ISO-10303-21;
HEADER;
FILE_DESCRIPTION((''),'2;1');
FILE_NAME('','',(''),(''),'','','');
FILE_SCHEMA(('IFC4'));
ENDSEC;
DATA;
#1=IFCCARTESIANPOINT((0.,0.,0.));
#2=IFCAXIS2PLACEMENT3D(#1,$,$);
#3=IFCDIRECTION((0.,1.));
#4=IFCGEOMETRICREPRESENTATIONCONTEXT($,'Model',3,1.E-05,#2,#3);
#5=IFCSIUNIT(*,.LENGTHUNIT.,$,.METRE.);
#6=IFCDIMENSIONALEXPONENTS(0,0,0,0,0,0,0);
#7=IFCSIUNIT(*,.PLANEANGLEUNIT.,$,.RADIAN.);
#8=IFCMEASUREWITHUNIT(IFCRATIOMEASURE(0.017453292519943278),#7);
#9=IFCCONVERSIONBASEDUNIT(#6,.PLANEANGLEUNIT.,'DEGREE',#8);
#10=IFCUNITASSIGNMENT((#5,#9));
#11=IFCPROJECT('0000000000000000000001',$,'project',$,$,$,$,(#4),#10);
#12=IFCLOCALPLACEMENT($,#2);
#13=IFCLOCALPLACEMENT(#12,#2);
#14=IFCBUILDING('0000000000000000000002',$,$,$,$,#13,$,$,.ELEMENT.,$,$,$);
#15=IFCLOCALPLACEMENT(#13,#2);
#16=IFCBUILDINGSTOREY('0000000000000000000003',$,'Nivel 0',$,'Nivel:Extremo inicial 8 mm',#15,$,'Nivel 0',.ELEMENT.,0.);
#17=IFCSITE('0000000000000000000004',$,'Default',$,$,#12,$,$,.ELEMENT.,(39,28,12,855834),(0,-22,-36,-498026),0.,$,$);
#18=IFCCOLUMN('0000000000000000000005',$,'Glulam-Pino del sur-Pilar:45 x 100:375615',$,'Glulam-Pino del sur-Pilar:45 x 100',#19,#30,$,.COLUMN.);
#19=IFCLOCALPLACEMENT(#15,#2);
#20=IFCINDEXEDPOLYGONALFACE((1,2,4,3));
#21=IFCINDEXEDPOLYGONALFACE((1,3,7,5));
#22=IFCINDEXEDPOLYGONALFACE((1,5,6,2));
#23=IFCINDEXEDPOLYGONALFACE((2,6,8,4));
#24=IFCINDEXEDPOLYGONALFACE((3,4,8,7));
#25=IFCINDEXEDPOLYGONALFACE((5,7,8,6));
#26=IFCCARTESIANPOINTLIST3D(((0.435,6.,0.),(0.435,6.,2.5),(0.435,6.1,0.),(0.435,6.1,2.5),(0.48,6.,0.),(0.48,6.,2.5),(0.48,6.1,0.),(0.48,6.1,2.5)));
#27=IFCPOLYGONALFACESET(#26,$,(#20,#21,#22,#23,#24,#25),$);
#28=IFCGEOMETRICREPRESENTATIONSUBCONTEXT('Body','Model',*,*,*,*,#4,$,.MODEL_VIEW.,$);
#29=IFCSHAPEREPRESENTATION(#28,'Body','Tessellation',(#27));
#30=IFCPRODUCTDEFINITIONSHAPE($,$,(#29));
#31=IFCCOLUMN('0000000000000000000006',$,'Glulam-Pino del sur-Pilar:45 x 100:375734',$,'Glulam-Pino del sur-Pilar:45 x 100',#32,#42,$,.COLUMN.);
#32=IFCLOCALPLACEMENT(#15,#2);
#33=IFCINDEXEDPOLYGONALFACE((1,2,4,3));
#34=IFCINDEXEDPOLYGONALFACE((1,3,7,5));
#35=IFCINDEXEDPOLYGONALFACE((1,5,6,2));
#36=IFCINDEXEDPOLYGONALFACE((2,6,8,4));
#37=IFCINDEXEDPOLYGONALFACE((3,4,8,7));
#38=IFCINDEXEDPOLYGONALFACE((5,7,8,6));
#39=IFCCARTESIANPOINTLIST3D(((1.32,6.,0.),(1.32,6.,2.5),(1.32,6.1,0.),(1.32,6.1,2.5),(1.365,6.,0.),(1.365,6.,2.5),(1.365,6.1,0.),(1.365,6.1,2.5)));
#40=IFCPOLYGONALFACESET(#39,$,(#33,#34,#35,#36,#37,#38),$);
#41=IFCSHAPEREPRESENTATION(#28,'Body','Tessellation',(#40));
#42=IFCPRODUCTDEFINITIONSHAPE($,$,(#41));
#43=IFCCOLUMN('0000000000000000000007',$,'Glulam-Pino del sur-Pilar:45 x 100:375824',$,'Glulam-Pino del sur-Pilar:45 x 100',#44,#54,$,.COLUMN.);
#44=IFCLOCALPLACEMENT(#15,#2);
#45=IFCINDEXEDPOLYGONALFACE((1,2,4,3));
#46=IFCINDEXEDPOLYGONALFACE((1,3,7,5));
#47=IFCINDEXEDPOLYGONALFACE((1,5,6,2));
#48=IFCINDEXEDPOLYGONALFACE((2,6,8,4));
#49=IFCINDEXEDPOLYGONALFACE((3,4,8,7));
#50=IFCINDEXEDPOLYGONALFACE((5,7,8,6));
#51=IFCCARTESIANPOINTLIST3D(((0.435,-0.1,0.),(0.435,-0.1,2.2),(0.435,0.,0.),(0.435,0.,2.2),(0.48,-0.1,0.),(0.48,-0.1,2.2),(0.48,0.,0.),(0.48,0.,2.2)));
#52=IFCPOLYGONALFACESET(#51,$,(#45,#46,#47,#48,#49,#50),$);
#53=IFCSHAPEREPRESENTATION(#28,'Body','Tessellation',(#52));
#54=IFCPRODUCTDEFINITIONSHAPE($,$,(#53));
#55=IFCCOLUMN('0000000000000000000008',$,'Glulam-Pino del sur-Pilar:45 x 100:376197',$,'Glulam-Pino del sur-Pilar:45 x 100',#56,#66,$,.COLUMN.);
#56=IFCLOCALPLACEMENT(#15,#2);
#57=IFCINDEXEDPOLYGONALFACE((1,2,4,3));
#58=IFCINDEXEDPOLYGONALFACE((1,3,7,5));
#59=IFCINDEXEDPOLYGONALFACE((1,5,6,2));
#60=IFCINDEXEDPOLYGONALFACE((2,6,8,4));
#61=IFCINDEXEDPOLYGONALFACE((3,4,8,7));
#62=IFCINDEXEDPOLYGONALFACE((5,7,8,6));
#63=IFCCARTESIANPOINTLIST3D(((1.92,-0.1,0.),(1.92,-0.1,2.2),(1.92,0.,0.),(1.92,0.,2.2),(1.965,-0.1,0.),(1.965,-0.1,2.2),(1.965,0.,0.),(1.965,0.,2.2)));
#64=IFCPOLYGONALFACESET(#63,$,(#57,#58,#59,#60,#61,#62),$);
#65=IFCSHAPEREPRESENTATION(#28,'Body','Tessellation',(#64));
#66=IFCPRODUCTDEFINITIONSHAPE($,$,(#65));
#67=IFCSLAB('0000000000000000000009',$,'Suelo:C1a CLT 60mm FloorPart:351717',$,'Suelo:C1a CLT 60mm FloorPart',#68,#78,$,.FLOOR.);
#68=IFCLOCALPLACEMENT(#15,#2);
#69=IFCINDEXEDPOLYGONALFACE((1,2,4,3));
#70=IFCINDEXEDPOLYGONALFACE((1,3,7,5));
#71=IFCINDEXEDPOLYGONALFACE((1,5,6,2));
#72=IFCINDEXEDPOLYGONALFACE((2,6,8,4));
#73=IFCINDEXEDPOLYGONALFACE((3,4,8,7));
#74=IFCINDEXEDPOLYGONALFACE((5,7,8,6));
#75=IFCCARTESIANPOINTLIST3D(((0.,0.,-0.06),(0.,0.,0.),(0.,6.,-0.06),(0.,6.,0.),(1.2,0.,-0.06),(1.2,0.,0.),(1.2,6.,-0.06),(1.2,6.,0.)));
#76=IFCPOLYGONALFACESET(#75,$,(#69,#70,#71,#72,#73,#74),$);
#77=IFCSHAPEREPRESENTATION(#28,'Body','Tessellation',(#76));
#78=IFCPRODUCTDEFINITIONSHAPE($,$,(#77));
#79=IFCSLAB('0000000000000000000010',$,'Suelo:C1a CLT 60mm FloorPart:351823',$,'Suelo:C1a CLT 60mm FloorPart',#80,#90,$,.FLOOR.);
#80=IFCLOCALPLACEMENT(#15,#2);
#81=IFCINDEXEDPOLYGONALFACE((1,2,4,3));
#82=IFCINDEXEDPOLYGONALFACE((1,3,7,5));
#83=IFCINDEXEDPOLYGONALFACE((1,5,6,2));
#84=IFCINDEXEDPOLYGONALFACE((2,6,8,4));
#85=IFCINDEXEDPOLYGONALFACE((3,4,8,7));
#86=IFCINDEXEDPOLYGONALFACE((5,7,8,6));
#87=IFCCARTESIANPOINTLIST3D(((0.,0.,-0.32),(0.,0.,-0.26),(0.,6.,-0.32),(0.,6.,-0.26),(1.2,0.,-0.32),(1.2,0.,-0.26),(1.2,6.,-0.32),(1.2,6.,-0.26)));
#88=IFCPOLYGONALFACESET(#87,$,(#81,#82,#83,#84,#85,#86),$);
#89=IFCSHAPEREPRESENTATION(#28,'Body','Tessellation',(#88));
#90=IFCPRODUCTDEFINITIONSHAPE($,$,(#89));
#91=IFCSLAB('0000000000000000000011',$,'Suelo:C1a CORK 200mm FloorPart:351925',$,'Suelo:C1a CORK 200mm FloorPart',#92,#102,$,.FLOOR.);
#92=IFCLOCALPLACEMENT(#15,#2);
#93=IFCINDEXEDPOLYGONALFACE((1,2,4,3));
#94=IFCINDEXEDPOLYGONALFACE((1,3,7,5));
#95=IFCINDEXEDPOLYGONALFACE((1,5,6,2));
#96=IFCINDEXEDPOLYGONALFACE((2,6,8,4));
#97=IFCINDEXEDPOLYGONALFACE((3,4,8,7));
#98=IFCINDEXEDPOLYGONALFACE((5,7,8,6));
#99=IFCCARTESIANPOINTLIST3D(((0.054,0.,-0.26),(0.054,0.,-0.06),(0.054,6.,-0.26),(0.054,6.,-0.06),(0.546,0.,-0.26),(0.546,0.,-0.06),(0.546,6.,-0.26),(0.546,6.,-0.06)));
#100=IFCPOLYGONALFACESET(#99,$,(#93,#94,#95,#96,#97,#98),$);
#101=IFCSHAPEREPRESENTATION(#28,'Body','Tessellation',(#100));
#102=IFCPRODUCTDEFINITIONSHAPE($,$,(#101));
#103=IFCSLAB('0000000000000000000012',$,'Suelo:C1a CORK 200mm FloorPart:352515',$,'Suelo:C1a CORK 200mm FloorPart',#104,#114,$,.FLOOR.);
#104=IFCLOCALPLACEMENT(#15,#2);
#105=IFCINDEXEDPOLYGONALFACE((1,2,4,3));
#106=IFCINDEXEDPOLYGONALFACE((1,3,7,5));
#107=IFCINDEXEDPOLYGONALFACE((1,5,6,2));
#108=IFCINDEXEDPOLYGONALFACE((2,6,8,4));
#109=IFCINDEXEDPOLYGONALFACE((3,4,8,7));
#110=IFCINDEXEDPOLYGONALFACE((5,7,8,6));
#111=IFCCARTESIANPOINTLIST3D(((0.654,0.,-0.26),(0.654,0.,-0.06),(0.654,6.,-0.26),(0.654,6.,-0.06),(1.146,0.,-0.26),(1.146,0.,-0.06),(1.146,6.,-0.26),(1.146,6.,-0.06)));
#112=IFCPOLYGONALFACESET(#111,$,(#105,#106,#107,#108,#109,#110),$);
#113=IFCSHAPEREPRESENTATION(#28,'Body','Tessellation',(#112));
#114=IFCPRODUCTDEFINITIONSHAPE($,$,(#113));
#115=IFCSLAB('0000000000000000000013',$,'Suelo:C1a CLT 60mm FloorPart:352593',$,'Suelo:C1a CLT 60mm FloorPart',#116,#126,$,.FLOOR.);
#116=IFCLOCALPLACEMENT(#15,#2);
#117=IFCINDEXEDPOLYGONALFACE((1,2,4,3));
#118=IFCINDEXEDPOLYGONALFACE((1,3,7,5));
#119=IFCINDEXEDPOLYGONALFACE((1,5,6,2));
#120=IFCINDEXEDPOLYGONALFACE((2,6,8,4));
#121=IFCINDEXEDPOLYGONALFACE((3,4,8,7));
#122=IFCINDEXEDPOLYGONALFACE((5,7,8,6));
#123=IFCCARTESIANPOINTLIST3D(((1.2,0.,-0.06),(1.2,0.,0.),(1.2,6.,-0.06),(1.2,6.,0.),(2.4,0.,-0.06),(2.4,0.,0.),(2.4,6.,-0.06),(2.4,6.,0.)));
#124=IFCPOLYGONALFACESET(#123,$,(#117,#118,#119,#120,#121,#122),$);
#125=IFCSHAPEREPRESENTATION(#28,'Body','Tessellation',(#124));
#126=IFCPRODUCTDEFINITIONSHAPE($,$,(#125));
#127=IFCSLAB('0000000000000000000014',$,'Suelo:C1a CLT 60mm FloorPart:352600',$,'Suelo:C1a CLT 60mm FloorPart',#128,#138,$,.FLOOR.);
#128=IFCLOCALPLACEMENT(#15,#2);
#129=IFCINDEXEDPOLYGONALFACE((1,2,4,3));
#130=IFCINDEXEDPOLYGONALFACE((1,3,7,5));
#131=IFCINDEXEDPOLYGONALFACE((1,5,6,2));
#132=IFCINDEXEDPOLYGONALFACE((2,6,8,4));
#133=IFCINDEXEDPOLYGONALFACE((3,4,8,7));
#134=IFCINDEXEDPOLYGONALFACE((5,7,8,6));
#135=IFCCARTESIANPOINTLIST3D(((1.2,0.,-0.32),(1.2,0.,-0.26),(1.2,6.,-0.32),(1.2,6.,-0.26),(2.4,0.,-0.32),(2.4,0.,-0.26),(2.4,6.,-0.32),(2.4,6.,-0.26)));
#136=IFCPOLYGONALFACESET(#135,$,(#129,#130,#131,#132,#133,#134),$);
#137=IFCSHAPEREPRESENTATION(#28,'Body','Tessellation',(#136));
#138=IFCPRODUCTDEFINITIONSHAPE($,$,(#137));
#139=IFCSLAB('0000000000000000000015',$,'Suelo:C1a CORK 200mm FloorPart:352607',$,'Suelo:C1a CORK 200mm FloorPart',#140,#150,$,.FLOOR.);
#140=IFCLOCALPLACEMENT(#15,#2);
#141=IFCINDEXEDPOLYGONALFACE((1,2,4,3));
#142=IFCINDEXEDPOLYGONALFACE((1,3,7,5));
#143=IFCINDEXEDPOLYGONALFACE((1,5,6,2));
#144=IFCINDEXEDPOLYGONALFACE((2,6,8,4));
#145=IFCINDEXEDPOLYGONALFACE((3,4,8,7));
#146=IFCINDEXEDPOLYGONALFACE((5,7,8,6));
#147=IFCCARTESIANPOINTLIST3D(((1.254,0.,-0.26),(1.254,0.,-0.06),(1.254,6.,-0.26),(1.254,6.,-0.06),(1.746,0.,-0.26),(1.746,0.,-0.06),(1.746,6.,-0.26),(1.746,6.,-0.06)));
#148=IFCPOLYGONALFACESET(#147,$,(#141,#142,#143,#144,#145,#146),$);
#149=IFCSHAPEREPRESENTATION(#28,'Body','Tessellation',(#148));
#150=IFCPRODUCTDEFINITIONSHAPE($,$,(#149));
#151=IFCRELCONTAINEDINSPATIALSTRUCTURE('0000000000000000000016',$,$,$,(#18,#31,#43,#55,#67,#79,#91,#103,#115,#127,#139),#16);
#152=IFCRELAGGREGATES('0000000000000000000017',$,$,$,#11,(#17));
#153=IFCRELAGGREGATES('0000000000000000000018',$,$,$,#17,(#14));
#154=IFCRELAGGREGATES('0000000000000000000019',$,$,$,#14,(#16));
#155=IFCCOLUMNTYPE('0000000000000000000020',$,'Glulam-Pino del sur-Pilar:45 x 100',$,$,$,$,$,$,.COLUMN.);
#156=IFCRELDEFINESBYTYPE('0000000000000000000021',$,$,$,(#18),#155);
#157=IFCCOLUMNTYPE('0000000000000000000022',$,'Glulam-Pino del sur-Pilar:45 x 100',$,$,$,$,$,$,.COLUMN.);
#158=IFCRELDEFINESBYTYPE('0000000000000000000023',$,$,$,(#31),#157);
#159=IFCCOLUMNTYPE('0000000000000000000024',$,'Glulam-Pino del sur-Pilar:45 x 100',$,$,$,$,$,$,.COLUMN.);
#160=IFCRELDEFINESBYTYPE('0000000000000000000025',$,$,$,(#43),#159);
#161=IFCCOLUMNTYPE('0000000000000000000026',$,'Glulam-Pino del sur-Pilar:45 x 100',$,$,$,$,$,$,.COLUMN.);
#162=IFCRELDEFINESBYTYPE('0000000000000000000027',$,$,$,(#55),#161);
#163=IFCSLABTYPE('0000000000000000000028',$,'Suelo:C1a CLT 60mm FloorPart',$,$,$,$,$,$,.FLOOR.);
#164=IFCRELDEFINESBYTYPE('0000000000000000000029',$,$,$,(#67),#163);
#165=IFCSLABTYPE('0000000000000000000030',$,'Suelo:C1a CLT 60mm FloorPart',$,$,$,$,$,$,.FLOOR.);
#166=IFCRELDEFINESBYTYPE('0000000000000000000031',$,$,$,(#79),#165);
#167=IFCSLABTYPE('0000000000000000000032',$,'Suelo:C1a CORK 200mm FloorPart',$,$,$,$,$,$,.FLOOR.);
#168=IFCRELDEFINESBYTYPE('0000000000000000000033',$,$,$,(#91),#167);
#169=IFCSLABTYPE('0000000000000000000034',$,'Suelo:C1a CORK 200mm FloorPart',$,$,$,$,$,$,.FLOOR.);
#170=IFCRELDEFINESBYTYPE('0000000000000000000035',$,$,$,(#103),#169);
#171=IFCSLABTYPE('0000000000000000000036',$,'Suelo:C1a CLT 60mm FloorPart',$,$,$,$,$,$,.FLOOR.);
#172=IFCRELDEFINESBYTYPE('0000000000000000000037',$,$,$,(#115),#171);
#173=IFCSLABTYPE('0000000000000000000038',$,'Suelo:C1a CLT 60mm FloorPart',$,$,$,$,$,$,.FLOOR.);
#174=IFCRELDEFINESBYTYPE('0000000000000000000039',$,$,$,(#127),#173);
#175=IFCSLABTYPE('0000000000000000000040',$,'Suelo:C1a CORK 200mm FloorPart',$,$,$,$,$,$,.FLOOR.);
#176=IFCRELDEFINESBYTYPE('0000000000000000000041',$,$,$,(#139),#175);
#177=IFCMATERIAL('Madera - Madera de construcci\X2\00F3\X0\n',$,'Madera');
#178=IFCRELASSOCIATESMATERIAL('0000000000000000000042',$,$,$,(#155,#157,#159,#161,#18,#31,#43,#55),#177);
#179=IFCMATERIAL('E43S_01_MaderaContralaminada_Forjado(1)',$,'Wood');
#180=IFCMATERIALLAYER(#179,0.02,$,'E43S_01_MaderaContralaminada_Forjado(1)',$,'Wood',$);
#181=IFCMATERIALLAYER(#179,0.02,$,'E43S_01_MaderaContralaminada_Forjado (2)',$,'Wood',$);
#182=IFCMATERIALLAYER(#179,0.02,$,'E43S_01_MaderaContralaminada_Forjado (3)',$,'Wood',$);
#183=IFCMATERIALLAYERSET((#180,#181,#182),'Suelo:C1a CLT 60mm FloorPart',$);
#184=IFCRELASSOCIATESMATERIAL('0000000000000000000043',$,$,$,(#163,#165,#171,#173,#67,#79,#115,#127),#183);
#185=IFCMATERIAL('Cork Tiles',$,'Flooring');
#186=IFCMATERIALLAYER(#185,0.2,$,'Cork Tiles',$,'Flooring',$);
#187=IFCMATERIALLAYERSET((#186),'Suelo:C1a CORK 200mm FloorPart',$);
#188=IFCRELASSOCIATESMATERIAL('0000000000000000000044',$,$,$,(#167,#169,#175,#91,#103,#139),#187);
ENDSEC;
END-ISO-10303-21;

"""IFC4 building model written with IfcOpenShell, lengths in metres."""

from ifc_helpers import new_model, entity, si_unit, converted_unit, direction, frame, frame_2d, origin, origin_2d_with_axis, place, context, subcontext, project, spatial, polyline, segment, composite_curve, rectangle, outline, extrude, source, transform, mapped, material, layer, layer_set, layer_usage, material_profile, profile_set, profile_usage, type_object, type_shapes, element, save


model = new_model("IFC4")

# Units and contexts
model_context = context("Model", 3, precision=1e-05, world=origin(), true_north=direction((0.0, 1.0)))
body_context = subcontext(model_context, "Body", "Model", "MODEL_VIEW")
ifc_project = project(units=[si_unit("LENGTHUNIT", "METRE"), converted_unit("PLANEANGLEUNIT", "DEGREE", entity("IfcRatioMeasure", 0.017453292519943278), si_unit("PLANEANGLEUNIT", "RADIAN"), dimensions=[0, 0, 0, 0, 0, 0, 0])], contexts=[model_context])

# Site, building, storey
site_placement = place(None, origin())
site = spatial("IfcSite", under=ifc_project, at=site_placement, Name="Default", CompositionType="ELEMENT", RefLatitude=(39, 28, 12, 855834), RefLongitude=(0, -22, -36, -498026), RefElevation=0.0)
building_placement = place(site_placement, origin())
building = spatial("IfcBuilding", under=site, at=building_placement, CompositionType="ELEMENT")
storey_placement = place(building_placement, origin())
storey = spatial("IfcBuildingStorey", under=building, at=storey_placement, Name="Nivel 0", ObjectType="Nivel:Extremo inicial 8 mm", LongName="Nivel 0", CompositionType="ELEMENT", Elevation=0.0)

# Columns
ifc_material_1 = material(Name="Madera - Madera de construcción", Category="Madera")
ifc_material_profile_1 = material_profile(ifc_material_1, outline(composite_curve([segment(polyline([(0.0225, 0.05, 0.0), (0.0225, -0.05, 0.0)]), True, "CONTINUOUS"), segment(polyline([(0.0225, -0.05, 0.0), (-0.0225, -0.05, 0.0)]), True, "CONTINUOUS"), segment(polyline([(-0.0225, -0.05, 0.0), (-0.0225, 0.05, 0.0)]), True, "CONTINUOUS"), segment(polyline([(-0.0225, 0.05, 0.0), (0.0225, 0.05, 0.0)]), True, "CONTINUOUS")], self_intersect=False), kind="CURVE"), Name="45 x 100")
ifc_material_profile_2 = material_profile(ifc_material_1, outline(composite_curve([segment(polyline([(0.0225, 0.05, 2.5), (-0.0225, 0.05, 2.5)]), True, "CONTINUOUS"), segment(polyline([(-0.0225, 0.05, 2.5), (-0.0225, -0.05, 2.5)]), True, "CONTINUOUS"), segment(polyline([(-0.0225, -0.05, 2.5), (0.0225, -0.05, 2.5)]), True, "CONTINUOUS"), segment(polyline([(0.0225, -0.05, 2.5), (0.0225, 0.05, 2.5)]), True, "CONTINUOUS")], self_intersect=False), kind="CURVE"), Name="45 x 100")
ifc_profile_set = profile_set([ifc_material_profile_1, ifc_material_profile_2], Name="45 x 100")
ifc_profile_usage_1 = profile_usage(ifc_profile_set)
column_type_1 = type_object("IfcColumnType", Name="Glulam-Pino del sur-Pilar:45 x 100", PredefinedType="COLUMN", material=ifc_profile_set)
shared_shape_1 = source(origin(), body_context, "Body", "SweptSolid", [
    extrude(rectangle(XDim=0.1, YDim=0.045, at=origin_2d_with_axis()), frame((0.0, 0.0, 0.0), z_axis=(0.0, 0.0, 1.0), x_axis=(0.0, -1.0, 0.0)), (0.0, 0.0, 1.0), 2.5),
])
type_shapes(column_type_1, [shared_shape_1])
column_1_placement = place(storey_placement, frame((0.4575, 6.05, 0.0)))
element("IfcColumn", 1, at=column_1_placement, inside=storey, type_object=column_type_1, material=ifc_profile_usage_1, Name="Glulam-Pino del sur-Pilar:45 x 100:375615", ObjectType="Glulam-Pino del sur-Pilar:45 x 100", PredefinedType="COLUMN", context=body_context, shape_type="MappedRepresentation", body=[
    mapped(shared_shape_1, transform((0.0, 0.0, 0.0), scale=1.0)),
])
ifc_profile_usage_2 = profile_usage(ifc_profile_set)
column_type_2 = type_object("IfcColumnType", Name="Glulam-Pino del sur-Pilar:45 x 100", PredefinedType="COLUMN", material=ifc_profile_set)
shared_shape_2 = source(origin(), body_context, "Body", "SweptSolid", [
    extrude(rectangle(XDim=0.1, YDim=0.045, at=origin_2d_with_axis()), frame((0.0, 0.0, 0.0), z_axis=(0.0, 0.0, 1.0), x_axis=(0.0, -1.0, 0.0)), (0.0, 0.0, 1.0), 2.5),
])
type_shapes(column_type_2, [shared_shape_2])
column_2_placement = place(storey_placement, frame((1.3425, 6.05, 0.0), z_axis=(0.0, 0.0, 1.0), x_axis=(-1.0, 0.0, 0.0)))
element("IfcColumn", 2, at=column_2_placement, inside=storey, type_object=column_type_2, material=ifc_profile_usage_2, Name="Glulam-Pino del sur-Pilar:45 x 100:375734", ObjectType="Glulam-Pino del sur-Pilar:45 x 100", PredefinedType="COLUMN", context=body_context, shape_type="MappedRepresentation", body=[
    mapped(shared_shape_2, transform((0.0, 0.0, 0.0), scale=1.0)),
])
ifc_profile_usage_3 = profile_usage(ifc_profile_set)
column_type_3 = type_object("IfcColumnType", Name="Glulam-Pino del sur-Pilar:45 x 100", PredefinedType="COLUMN", material=ifc_profile_set)
shared_shape_3 = source(origin(), body_context, "Body", "SweptSolid", [
    extrude(rectangle(XDim=0.1, YDim=0.045, at=origin_2d_with_axis()), frame((0.0, 0.0, 0.0), z_axis=(0.0, 0.0, 1.0), x_axis=(0.0, -1.0, 0.0)), (0.0, 0.0, 1.0), 2.2),
])
type_shapes(column_type_3, [shared_shape_3])
column_3_placement = place(storey_placement, frame((0.4575, -0.05, 0.0), z_axis=(0.0, 0.0, 1.0), x_axis=(-1.0, 0.0, 0.0)))
element("IfcColumn", 3, at=column_3_placement, inside=storey, type_object=column_type_3, material=ifc_profile_usage_3, Name="Glulam-Pino del sur-Pilar:45 x 100:375824", ObjectType="Glulam-Pino del sur-Pilar:45 x 100", PredefinedType="COLUMN", context=body_context, shape_type="MappedRepresentation", body=[
    mapped(shared_shape_3, transform((0.0, 0.0, 0.0), scale=1.0)),
])
ifc_profile_usage_4 = profile_usage(ifc_profile_set)
column_type_4 = type_object("IfcColumnType", Name="Glulam-Pino del sur-Pilar:45 x 100", PredefinedType="COLUMN", material=ifc_profile_set)
shared_shape_4 = source(origin(), body_context, "Body", "SweptSolid", [
    extrude(rectangle(XDim=0.1, YDim=0.045, at=origin_2d_with_axis()), frame((0.0, 0.0, 0.0), z_axis=(0.0, 0.0, 1.0), x_axis=(0.0, -1.0, 0.0)), (0.0, 0.0, 1.0), 2.2),
])
type_shapes(column_type_4, [shared_shape_4])
column_4_placement = place(storey_placement, frame((1.9425, -0.05, 0.0)))
element("IfcColumn", 4, at=column_4_placement, inside=storey, type_object=column_type_4, material=ifc_profile_usage_4, Name="Glulam-Pino del sur-Pilar:45 x 100:376197", ObjectType="Glulam-Pino del sur-Pilar:45 x 100", PredefinedType="COLUMN", context=body_context, shape_type="MappedRepresentation", body=[
    mapped(shared_shape_4, transform((0.0, 0.0, 0.0), scale=1.0)),
])

# Slabs
ifc_material_2 = material(Name="E43S_01_MaderaContralaminada_Forjado(1)", Category="Wood")
ifc_layer_1 = layer(ifc_material_2, 0.02, Name="E43S_01_MaderaContralaminada_Forjado(1)", Category="Wood")
ifc_layer_2 = layer(ifc_material_2, 0.02, Name="E43S_01_MaderaContralaminada_Forjado (2)", Category="Wood")
ifc_layer_3 = layer(ifc_material_2, 0.02, Name="E43S_01_MaderaContralaminada_Forjado (3)", Category="Wood")
ifc_layer_set_1 = layer_set([ifc_layer_1, ifc_layer_2, ifc_layer_3], Name="Suelo:C1a CLT 60mm FloorPart")
ifc_layer_usage_1 = layer_usage(ifc_layer_set_1, "AXIS3", "POSITIVE", 0.0)
slab_type_1 = type_object("IfcSlabType", Name="Suelo:C1a CLT 60mm FloorPart", PredefinedType="FLOOR", material=ifc_layer_set_1)
slab_1_placement = place(storey_placement, origin())
element("IfcSlab", 5, at=slab_1_placement, inside=storey, type_object=slab_type_1, material=ifc_layer_usage_1, Name="Suelo:C1a CLT 60mm FloorPart:351717", ObjectType="Suelo:C1a CLT 60mm FloorPart", PredefinedType="FLOOR", context=body_context, shape_type="SweptSolid", body=[
    extrude(rectangle(XDim=6.0, YDim=1.2, at=frame_2d((0.0, 0.0), x_axis=(1.0, 0.0))), frame((0.6, 3.0, 0.0), z_axis=(0.0, 0.0, -1.0), x_axis=(0.0, 1.0, 0.0)), (0.0, 0.0, 1.0), 0.06),
])
ifc_layer_usage_2 = layer_usage(ifc_layer_set_1, "AXIS3", "POSITIVE", 0.0)
slab_type_2 = type_object("IfcSlabType", Name="Suelo:C1a CLT 60mm FloorPart", PredefinedType="FLOOR", material=ifc_layer_set_1)
slab_2_placement = place(storey_placement, origin())
element("IfcSlab", 6, at=slab_2_placement, inside=storey, type_object=slab_type_2, material=ifc_layer_usage_2, Name="Suelo:C1a CLT 60mm FloorPart:351823", ObjectType="Suelo:C1a CLT 60mm FloorPart", PredefinedType="FLOOR", context=body_context, shape_type="SweptSolid", body=[
    extrude(rectangle(XDim=6.0, YDim=1.2, at=frame_2d((0.0, 0.0), x_axis=(1.0, 0.0))), frame((0.6, 3.0, -0.26), z_axis=(0.0, 0.0, -1.0), x_axis=(0.0, 1.0, 0.0)), (0.0, 0.0, 1.0), 0.06),
])
ifc_material_3 = material(Name="Cork Tiles", Category="Flooring")
ifc_layer_4 = layer(ifc_material_3, 0.2, Name="Cork Tiles", Category="Flooring")
ifc_layer_set_2 = layer_set([ifc_layer_4], Name="Suelo:C1a CORK 200mm FloorPart")
ifc_layer_usage_3 = layer_usage(ifc_layer_set_2, "AXIS3", "POSITIVE", 0.0)
slab_type_3 = type_object("IfcSlabType", Name="Suelo:C1a CORK 200mm FloorPart", PredefinedType="FLOOR", material=ifc_layer_set_2)
slab_3_placement = place(storey_placement, origin())
element("IfcSlab", 7, at=slab_3_placement, inside=storey, type_object=slab_type_3, material=ifc_layer_usage_3, Name="Suelo:C1a CORK 200mm FloorPart:351925", ObjectType="Suelo:C1a CORK 200mm FloorPart", PredefinedType="FLOOR", context=body_context, shape_type="SweptSolid", body=[
    extrude(rectangle(XDim=6.0, YDim=0.492, at=frame_2d((0.0, 0.0), x_axis=(1.0, 0.0))), frame((0.3, 3.0, -0.06), z_axis=(0.0, 0.0, -1.0), x_axis=(0.0, 1.0, 0.0)), (0.0, 0.0, 1.0), 0.2),
])
ifc_layer_usage_4 = layer_usage(ifc_layer_set_2, "AXIS3", "POSITIVE", 0.0)
slab_type_4 = type_object("IfcSlabType", Name="Suelo:C1a CORK 200mm FloorPart", PredefinedType="FLOOR", material=ifc_layer_set_2)
slab_4_placement = place(storey_placement, origin())
element("IfcSlab", 8, at=slab_4_placement, inside=storey, type_object=slab_type_4, material=ifc_layer_usage_4, Name="Suelo:C1a CORK 200mm FloorPart:352515", ObjectType="Suelo:C1a CORK 200mm FloorPart", PredefinedType="FLOOR", context=body_context, shape_type="SweptSolid", body=[
    extrude(rectangle(XDim=6.0, YDim=0.492, at=frame_2d((0.0, 0.0), x_axis=(1.0, 0.0))), frame((0.9, 3.0, -0.06), z_axis=(0.0, 0.0, -1.0), x_axis=(0.0, 1.0, 0.0)), (0.0, 0.0, 1.0), 0.2),
])
ifc_layer_usage_5 = layer_usage(ifc_layer_set_1, "AXIS3", "POSITIVE", 0.0)
slab_type_5 = type_object("IfcSlabType", Name="Suelo:C1a CLT 60mm FloorPart", PredefinedType="FLOOR", material=ifc_layer_set_1)
slab_5_placement = place(storey_placement, origin())
element("IfcSlab", 9, at=slab_5_placement, inside=storey, type_object=slab_type_5, material=ifc_layer_usage_5, Name="Suelo:C1a CLT 60mm FloorPart:352593", ObjectType="Suelo:C1a CLT 60mm FloorPart", PredefinedType="FLOOR", context=body_context, shape_type="SweptSolid", body=[
    extrude(rectangle(XDim=6.0, YDim=1.2, at=frame_2d((0.0, 0.0), x_axis=(1.0, 0.0))), frame((1.8, 3.0, 0.0), z_axis=(0.0, 0.0, -1.0), x_axis=(0.0, 1.0, 0.0)), (0.0, 0.0, 1.0), 0.06),
])
ifc_layer_usage_6 = layer_usage(ifc_layer_set_1, "AXIS3", "POSITIVE", 0.0)
slab_type_6 = type_object("IfcSlabType", Name="Suelo:C1a CLT 60mm FloorPart", PredefinedType="FLOOR", material=ifc_layer_set_1)
slab_6_placement = place(storey_placement, origin())
element("IfcSlab", 10, at=slab_6_placement, inside=storey, type_object=slab_type_6, material=ifc_layer_usage_6, Name="Suelo:C1a CLT 60mm FloorPart:352600", ObjectType="Suelo:C1a CLT 60mm FloorPart", PredefinedType="FLOOR", context=body_context, shape_type="SweptSolid", body=[
    extrude(rectangle(XDim=6.0, YDim=1.2, at=frame_2d((0.0, 0.0), x_axis=(1.0, 0.0))), frame((1.8, 3.0, -0.26), z_axis=(0.0, 0.0, -1.0), x_axis=(0.0, 1.0, 0.0)), (0.0, 0.0, 1.0), 0.06),
])
ifc_layer_usage_7 = layer_usage(ifc_layer_set_2, "AXIS3", "POSITIVE", 0.0)
slab_type_7 = type_object("IfcSlabType", Name="Suelo:C1a CORK 200mm FloorPart", PredefinedType="FLOOR", material=ifc_layer_set_2)
slab_7_placement = place(storey_placement, origin())
element("IfcSlab", 11, at=slab_7_placement, inside=storey, type_object=slab_type_7, material=ifc_layer_usage_7, Name="Suelo:C1a CORK 200mm FloorPart:352607", ObjectType="Suelo:C1a CORK 200mm FloorPart", PredefinedType="FLOOR", context=body_context, shape_type="SweptSolid", body=[
    extrude(rectangle(XDim=6.0, YDim=0.492, at=frame_2d((0.0, 0.0), x_axis=(1.0, 0.0))), frame((1.5, 3.0, -0.06), z_axis=(0.0, 0.0, -1.0), x_axis=(0.0, 1.0, 0.0)), (0.0, 0.0, 1.0), 0.2),
])

save(model, "model.ifc")
